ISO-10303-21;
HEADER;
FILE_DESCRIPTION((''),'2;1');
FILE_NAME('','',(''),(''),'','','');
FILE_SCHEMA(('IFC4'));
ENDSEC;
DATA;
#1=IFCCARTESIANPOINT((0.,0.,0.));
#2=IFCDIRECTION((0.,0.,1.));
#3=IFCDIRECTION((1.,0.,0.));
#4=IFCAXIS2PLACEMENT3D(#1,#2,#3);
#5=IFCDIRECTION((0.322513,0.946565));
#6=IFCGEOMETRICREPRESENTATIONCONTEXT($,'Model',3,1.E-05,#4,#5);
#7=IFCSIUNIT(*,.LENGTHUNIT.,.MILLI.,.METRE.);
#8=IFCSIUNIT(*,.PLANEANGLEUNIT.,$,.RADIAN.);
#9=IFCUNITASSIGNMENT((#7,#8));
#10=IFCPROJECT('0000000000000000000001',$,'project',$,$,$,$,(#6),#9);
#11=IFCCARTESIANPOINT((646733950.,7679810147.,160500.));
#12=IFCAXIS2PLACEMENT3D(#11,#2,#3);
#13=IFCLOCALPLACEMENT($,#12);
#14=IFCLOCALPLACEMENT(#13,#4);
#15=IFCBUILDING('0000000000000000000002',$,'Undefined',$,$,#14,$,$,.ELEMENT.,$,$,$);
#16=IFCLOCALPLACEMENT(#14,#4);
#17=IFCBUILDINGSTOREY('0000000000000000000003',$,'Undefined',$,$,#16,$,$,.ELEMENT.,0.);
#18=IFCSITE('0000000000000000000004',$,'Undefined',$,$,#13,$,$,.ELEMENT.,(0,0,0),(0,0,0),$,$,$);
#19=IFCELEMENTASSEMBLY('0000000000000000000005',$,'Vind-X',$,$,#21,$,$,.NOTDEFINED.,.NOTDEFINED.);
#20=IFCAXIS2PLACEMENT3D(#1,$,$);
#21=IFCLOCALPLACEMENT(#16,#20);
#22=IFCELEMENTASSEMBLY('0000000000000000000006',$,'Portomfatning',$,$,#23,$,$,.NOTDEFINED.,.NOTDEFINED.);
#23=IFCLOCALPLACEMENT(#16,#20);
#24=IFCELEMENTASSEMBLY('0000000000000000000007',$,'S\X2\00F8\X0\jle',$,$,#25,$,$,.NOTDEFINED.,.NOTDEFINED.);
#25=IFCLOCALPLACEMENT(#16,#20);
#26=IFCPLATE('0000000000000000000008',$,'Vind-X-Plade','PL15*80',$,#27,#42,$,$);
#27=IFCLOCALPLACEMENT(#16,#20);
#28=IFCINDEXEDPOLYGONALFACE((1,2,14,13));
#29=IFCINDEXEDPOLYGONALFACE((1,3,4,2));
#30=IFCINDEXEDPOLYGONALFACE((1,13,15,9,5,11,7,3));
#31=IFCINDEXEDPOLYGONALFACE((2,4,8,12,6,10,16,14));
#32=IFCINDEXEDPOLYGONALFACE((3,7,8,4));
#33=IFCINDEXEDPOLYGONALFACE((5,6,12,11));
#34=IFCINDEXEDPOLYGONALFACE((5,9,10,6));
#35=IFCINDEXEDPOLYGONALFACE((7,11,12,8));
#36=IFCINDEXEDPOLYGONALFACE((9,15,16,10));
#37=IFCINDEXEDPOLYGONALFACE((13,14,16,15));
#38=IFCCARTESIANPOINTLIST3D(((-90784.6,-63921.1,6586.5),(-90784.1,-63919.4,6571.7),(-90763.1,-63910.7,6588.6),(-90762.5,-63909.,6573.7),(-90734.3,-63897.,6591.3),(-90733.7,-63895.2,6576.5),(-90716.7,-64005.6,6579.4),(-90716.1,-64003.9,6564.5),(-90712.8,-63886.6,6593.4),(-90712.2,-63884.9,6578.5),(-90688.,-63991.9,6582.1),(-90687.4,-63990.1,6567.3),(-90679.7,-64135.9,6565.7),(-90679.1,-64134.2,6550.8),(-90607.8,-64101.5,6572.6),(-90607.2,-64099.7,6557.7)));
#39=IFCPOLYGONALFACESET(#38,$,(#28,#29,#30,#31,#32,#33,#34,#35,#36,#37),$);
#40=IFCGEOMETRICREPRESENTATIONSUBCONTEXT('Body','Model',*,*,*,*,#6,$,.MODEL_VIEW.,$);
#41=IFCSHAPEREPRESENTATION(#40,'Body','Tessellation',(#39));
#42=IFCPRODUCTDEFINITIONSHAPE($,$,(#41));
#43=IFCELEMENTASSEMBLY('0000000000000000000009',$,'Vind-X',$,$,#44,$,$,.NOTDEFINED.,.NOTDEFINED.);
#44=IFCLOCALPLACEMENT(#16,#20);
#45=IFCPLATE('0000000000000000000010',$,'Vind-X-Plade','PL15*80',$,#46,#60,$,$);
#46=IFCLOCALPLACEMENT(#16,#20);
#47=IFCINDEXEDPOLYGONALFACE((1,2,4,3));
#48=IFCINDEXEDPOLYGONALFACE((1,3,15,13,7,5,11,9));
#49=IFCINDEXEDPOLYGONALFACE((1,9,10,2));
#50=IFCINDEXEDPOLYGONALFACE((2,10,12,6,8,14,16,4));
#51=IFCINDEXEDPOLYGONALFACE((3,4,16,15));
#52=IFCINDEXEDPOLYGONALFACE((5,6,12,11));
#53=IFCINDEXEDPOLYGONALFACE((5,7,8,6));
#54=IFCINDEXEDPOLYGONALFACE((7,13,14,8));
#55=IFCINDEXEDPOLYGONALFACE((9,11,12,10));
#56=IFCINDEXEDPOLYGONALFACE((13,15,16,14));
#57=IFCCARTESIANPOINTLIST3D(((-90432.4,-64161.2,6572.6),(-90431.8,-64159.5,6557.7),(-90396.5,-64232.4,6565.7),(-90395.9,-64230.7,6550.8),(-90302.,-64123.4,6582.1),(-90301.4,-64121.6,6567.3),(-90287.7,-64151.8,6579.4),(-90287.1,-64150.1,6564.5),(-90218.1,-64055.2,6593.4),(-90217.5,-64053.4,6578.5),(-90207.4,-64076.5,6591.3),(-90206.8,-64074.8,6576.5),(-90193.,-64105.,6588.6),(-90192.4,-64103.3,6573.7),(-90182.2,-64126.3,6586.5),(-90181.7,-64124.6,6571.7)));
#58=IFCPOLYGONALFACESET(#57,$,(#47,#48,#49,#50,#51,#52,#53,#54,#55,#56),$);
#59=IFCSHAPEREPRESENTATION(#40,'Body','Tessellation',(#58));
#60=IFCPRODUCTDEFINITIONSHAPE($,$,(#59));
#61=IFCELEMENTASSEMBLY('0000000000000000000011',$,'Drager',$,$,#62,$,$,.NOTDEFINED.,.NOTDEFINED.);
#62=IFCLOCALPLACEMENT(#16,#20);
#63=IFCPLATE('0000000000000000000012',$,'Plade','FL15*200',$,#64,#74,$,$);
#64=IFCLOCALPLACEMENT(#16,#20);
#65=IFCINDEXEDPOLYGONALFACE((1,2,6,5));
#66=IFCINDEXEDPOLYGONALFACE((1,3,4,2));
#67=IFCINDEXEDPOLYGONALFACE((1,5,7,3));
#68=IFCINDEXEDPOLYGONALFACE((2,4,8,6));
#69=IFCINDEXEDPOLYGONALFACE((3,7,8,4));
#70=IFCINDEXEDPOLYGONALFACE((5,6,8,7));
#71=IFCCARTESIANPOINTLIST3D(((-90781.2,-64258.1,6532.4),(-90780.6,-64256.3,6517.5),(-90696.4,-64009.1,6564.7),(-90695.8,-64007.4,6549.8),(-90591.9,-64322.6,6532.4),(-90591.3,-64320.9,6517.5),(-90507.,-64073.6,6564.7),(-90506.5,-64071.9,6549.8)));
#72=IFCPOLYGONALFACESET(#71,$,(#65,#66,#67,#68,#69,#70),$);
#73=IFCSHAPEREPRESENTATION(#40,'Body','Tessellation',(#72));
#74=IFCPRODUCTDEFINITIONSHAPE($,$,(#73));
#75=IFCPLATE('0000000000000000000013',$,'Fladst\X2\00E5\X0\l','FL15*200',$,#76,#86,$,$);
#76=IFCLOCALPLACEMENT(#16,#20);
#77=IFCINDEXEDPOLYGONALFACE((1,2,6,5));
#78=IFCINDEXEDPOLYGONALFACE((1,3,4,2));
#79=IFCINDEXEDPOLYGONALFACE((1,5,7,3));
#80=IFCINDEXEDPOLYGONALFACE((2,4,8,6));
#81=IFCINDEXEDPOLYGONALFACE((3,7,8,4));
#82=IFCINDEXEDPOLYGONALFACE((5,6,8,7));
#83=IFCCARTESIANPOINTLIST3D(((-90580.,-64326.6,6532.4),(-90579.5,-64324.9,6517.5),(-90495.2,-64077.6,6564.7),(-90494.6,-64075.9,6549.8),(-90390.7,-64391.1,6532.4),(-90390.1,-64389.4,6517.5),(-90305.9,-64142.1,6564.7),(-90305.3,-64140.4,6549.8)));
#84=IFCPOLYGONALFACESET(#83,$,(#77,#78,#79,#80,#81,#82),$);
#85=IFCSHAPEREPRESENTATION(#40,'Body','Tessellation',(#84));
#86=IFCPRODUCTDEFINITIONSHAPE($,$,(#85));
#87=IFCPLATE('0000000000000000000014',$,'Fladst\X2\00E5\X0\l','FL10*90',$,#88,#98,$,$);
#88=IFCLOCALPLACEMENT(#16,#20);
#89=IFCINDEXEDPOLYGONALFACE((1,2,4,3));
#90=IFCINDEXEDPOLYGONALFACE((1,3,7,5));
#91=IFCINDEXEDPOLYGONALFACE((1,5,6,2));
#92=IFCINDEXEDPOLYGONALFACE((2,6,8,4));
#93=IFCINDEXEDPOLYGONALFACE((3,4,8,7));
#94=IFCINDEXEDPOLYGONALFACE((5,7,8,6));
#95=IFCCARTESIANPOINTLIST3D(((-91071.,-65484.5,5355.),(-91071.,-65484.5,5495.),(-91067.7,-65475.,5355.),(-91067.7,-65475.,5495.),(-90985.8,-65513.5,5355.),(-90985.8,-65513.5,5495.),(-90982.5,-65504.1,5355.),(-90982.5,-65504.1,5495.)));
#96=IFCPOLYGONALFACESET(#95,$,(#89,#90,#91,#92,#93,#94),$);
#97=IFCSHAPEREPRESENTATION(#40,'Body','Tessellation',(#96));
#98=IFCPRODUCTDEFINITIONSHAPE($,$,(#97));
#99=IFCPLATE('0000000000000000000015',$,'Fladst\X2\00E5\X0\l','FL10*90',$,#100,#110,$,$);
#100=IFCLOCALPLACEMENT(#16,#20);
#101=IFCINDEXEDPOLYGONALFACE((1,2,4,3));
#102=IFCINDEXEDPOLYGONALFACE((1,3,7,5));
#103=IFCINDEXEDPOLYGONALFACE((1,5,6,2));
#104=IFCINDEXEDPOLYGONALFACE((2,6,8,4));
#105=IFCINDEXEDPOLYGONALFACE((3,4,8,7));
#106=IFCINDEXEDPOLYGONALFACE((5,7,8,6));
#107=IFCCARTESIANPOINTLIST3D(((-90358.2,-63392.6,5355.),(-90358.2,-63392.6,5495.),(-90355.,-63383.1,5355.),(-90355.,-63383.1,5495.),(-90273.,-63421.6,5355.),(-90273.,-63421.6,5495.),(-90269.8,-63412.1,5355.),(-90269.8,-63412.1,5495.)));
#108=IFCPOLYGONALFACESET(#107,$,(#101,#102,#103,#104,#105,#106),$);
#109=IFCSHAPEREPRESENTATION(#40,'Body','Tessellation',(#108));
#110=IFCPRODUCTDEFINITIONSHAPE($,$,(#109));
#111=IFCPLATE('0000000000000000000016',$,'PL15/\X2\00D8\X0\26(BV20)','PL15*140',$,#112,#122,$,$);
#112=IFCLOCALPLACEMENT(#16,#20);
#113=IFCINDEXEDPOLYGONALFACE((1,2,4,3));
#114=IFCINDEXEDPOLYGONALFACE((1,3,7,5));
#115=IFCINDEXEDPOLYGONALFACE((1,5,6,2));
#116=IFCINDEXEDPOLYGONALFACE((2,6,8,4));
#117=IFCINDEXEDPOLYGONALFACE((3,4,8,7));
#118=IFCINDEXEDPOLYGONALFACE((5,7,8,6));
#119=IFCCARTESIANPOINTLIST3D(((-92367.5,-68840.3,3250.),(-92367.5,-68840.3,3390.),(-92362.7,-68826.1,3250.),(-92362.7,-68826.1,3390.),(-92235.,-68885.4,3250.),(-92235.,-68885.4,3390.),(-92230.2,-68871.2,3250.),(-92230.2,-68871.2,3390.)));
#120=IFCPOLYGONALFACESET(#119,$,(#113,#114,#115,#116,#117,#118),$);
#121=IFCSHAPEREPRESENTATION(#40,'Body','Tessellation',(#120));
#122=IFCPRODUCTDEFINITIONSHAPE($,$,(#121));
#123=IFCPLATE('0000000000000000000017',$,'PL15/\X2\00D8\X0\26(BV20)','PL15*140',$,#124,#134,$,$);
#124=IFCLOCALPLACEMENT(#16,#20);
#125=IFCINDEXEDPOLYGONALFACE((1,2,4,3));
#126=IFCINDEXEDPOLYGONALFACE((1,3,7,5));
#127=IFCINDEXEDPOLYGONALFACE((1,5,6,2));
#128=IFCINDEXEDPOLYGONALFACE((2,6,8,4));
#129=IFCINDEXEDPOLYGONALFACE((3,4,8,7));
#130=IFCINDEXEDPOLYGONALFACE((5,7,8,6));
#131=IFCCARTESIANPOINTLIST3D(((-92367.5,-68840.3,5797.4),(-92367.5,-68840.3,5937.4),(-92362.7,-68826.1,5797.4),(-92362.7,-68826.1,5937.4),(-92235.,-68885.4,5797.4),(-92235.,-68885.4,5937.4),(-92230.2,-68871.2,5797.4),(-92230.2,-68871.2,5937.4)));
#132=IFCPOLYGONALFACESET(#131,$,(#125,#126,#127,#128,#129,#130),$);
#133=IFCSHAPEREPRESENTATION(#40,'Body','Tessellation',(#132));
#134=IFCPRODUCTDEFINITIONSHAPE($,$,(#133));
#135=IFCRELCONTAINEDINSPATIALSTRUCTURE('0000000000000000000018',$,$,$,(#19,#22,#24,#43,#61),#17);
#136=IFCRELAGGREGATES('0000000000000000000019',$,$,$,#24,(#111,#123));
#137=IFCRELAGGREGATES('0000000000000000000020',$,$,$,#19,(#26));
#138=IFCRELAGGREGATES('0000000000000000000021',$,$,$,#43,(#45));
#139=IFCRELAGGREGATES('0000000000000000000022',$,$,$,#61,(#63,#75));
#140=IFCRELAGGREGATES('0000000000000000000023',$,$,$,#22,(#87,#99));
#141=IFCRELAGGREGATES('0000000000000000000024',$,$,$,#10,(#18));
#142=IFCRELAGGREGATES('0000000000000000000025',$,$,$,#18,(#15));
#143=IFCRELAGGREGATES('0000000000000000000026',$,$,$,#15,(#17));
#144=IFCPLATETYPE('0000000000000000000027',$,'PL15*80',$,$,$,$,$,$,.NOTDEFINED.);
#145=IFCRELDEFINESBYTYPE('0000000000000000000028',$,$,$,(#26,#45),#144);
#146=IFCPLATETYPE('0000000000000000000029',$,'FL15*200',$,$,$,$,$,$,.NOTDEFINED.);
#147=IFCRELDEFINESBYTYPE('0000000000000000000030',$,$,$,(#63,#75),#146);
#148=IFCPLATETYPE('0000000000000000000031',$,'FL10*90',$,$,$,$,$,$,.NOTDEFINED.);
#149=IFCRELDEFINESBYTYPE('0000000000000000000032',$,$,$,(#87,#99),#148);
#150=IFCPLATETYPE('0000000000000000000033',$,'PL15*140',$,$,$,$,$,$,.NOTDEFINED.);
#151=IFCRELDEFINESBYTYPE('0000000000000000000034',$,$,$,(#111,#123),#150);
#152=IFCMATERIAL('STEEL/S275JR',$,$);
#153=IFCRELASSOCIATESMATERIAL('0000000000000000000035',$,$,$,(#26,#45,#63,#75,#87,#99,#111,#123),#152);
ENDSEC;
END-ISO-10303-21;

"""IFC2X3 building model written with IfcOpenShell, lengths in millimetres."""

from ifc_helpers import new_model, si_unit, direction, frame, origin_with_axes, place, context, subcontext, project, spatial, polyline, outline, extrude, boolean, material, type_object, element, aggregate, save


model = new_model("IFC2X3")

# Units and contexts
model_context = context("Model", 3, precision=1e-05, world=origin_with_axes(), true_north=direction((0.322513, 0.946565)))
body_context = subcontext(model_context, "Body", "Model", "MODEL_VIEW")
ifc_project = project(units=[si_unit("LENGTHUNIT", "METRE", prefix="MILLI"), si_unit("PLANEANGLEUNIT", "RADIAN")], contexts=[model_context])

# Site, building, storey
site_placement = place(None, frame((646733950.0, 7679810147.0, 160500.0), z_axis=(0.0, 0.0, 1.0), x_axis=(1.0, 0.0, 0.0)))
site = spatial("IfcSite", under=ifc_project, at=site_placement, Name="Undefined", CompositionType="ELEMENT", RefLatitude=(0, 0, 0), RefLongitude=(0, 0, 0))
building_placement = place(site_placement, origin_with_axes())
building = spatial("IfcBuilding", under=site, at=building_placement, Name="Undefined", CompositionType="ELEMENT")
storey_placement = place(building_placement, origin_with_axes())
storey = spatial("IfcBuildingStorey", under=building, at=storey_placement, Name="Undefined", CompositionType="ELEMENT", Elevation=0.0)

# Element assembly
assembly_1_placement = place(storey_placement, origin_with_axes())
assembly_1 = element("IfcElementAssembly", 1, at=assembly_1_placement, inside=storey, Name="Vind-X", AssemblyPlace="NOTDEFINED", PredefinedType="NOTDEFINED")

# Element assembly
assembly_2_placement = place(storey_placement, origin_with_axes())
assembly_2 = element("IfcElementAssembly", 2, at=assembly_2_placement, inside=storey, Name="Portomfatning", AssemblyPlace="NOTDEFINED", PredefinedType="NOTDEFINED")

# Element assembly
assembly_3_placement = place(storey_placement, origin_with_axes())
assembly_3 = element("IfcElementAssembly", 3, at=assembly_3_placement, inside=storey, Name="Søjle", AssemblyPlace="NOTDEFINED", PredefinedType="NOTDEFINED")
ifc_material_1 = material(Name="STEEL/S275JR")

# Plate
plate_type_1 = type_object("IfcPlateType", Name="PL15*80", PredefinedType="NOTDEFINED")
plate_1_placement = place(assembly_1_placement, frame((-90679.4, -64135.1, 6558.3), z_axis=(-0.039304, -0.115357, 0.992546), x_axis=(0.898474, 0.430595, 0.085625)))
plate_1 = element("IfcPlate", 4, at=plate_1_placement, type_object=plate_type_1, material=ifc_material_1, Name="Vind-X-Plade", Description="PL15*80", context=body_context, shape_type="CSG", body=[
    boolean("DIFFERENCE", extrude(outline(polyline([(0.0, 0.0), (80.0, 0.0), (80.0, 240.0), (0.0, 240.0), (0.0, 0.0)])), frame((0.0, 0.0, -7.5), z_axis=(0.0, 0.0, 1.0), x_axis=(1.0, 0.0, 0.0)), (0.0, 0.0, 1.0), 15.0), extrude(outline(polyline([(0.0, 0.0), (106.0, 0.0), (106.0, 32.0), (0.0, 32.0), (0.0, 0.0)])), frame((56.0, 240.0, 8.5), z_axis=(0.0, 0.0, -1.0), x_axis=(0.0, -1.0, 0.0)), (0.0, 0.0, 1.0), 17.0)),
])

# Element assembly, plate
assembly_4_placement = place(storey_placement, origin_with_axes())
assembly_4 = element("IfcElementAssembly", 5, at=assembly_4_placement, inside=storey, Name="Vind-X", AssemblyPlace="NOTDEFINED", PredefinedType="NOTDEFINED")
plate_2_placement = place(assembly_4_placement, frame((-90396.2, -64231.5, 6558.3), z_axis=(0.039304, 0.115357, -0.992546), x_axis=(-0.448662, 0.88959, 0.085625)))
plate_2 = element("IfcPlate", 6, at=plate_2_placement, type_object=plate_type_1, material=ifc_material_1, Name="Vind-X-Plade", Description="PL15*80", context=body_context, shape_type="CSG", body=[
    boolean("DIFFERENCE", extrude(outline(polyline([(0.0, 0.0), (80.0, 0.0), (80.0, 240.0), (0.0, 240.0), (0.0, 0.0)])), frame((0.0, 0.0, -7.5), z_axis=(0.0, 0.0, 1.0), x_axis=(1.0, 0.0, 0.0)), (0.0, 0.0, 1.0), 15.0), extrude(outline(polyline([(0.0, 0.0), (106.0, 0.0), (106.0, 32.0), (0.0, 32.0), (0.0, 0.0)])), frame((56.0, 240.0, 8.5), z_axis=(0.0, 0.0, -1.0), x_axis=(0.0, -1.0, 0.0)), (0.0, 0.0, 1.0), 17.0)),
])

# Element assembly, plates
assembly_5_placement = place(storey_placement, origin_with_axes())
assembly_5 = element("IfcElementAssembly", 7, at=assembly_5_placement, inside=storey, Name="Drager", AssemblyPlace="NOTDEFINED", PredefinedType="NOTDEFINED")
plate_type_2 = type_object("IfcPlateType", Name="FL15*200", PredefinedType="NOTDEFINED")
plate_3_placement = place(assembly_5_placement, frame((-90591.6, -64321.7, 6524.9), z_axis=(-0.039304, -0.115357, 0.992546), x_axis=(0.320109, 0.93951, 0.121869)))
plate_3 = element("IfcPlate", 8, at=plate_3_placement, type_object=plate_type_2, material=ifc_material_1, Name="Plade", Description="FL15*200", context=body_context, shape_type="SweptSolid", body=[
    extrude(outline(polyline([(0.0, 0.0), (265.0, 0.0), (265.0, 200.0), (0.0, 200.0), (0.0, 0.0)])), frame((0.0, 0.0, -7.5), z_axis=(0.0, 0.0, 1.0), x_axis=(1.0, 0.0, 0.0)), (0.0, 0.0, 1.0), 15.0),
])
plate_4_placement = place(assembly_5_placement, frame((-90494.9, -64076.8, 6557.2), z_axis=(-0.039304, -0.115357, 0.992546), x_axis=(-0.320109, -0.93951, -0.121869)))
plate_4 = element("IfcPlate", 9, at=plate_4_placement, type_object=plate_type_2, material=ifc_material_1, Name="Fladstål", Description="FL15*200", context=body_context, shape_type="SweptSolid", body=[
    extrude(outline(polyline([(0.0, 0.0), (265.0, 0.0), (265.0, 200.0), (0.0, 200.0), (0.0, 0.0)])), frame((0.0, 0.0, -7.5), z_axis=(0.0, 0.0, 1.0), x_axis=(1.0, 0.0, 0.0)), (0.0, 0.0, 1.0), 15.0),
])

# Plates
plate_type_3 = type_object("IfcPlateType", Name="FL10*90", PredefinedType="NOTDEFINED")
plate_5_placement = place(assembly_2_placement, frame((-91026.8, -65494.3, 5355.0), z_axis=(0.322513, 0.946565, 0.0), x_axis=(0.0, 0.0, 1.0)))
plate_5 = element("IfcPlate", 10, at=plate_5_placement, type_object=plate_type_3, material=ifc_material_1, Name="Fladstål", Description="FL10*90", context=body_context, shape_type="SweptSolid", body=[
    extrude(outline(polyline([(0.0, -45.0), (0.0, 45.0), (140.0, 45.0), (140.0, -45.0), (0.0, -45.0)])), frame((0.0, 0.0, -5.0), z_axis=(0.0, 0.0, 1.0), x_axis=(1.0, 0.0, 0.0)), (0.0, 0.0, 1.0), 10.0),
])
plate_6_placement = place(assembly_2_placement, frame((-90314.0, -63402.4, 5355.0), z_axis=(-0.322513, -0.946565, 0.0), x_axis=(0.0, 0.0, 1.0)))
plate_6 = element("IfcPlate", 11, at=plate_6_placement, type_object=plate_type_3, material=ifc_material_1, Name="Fladstål", Description="FL10*90", context=body_context, shape_type="SweptSolid", body=[
    extrude(outline(polyline([(0.0, -45.0), (0.0, 45.0), (140.0, 45.0), (140.0, -45.0), (0.0, -45.0)])), frame((0.0, 0.0, -5.0), z_axis=(0.0, 0.0, 1.0), x_axis=(1.0, 0.0, 0.0)), (0.0, 0.0, 1.0), 10.0),
])
plate_type_4 = type_object("IfcPlateType", Name="PL15*140", PredefinedType="NOTDEFINED")
plate_7_placement = place(assembly_3_placement, frame((-92365.1, -68833.2, 3250.0), z_axis=(-0.322513, -0.946565, 0.0), x_axis=(0.946565, -0.322513, 0.0)))
plate_7 = element("IfcPlate", 12, at=plate_7_placement, type_object=plate_type_4, material=ifc_material_1, Name="PL15/Ø26(BV20)", Description="PL15*140", context=body_context, shape_type="SweptSolid", body=[
    extrude(outline(polyline([(0.0, 0.0), (140.0, 0.0), (140.0, 140.0), (0.0, 140.0), (0.0, 0.0)])), frame((0.0, 0.0, -7.5), z_axis=(0.0, 0.0, 1.0), x_axis=(1.0, 0.0, 0.0)), (0.0, 0.0, 1.0), 15.0),
])
plate_8_placement = place(assembly_3_placement, frame((-92365.1, -68833.2, 5797.4), z_axis=(-0.322513, -0.946565, 0.0), x_axis=(0.946565, -0.322513, 0.0)))
plate_8 = element("IfcPlate", 13, at=plate_8_placement, type_object=plate_type_4, material=ifc_material_1, Name="PL15/Ø26(BV20)", Description="PL15*140", context=body_context, shape_type="SweptSolid", body=[
    extrude(outline(polyline([(0.0, 0.0), (140.0, 0.0), (140.0, 140.0), (0.0, 140.0), (0.0, 0.0)])), frame((0.0, 0.0, -7.5), z_axis=(0.0, 0.0, 1.0), x_axis=(1.0, 0.0, 0.0)), (0.0, 0.0, 1.0), 15.0),
])
aggregate(assembly_3, [plate_7, plate_8])

aggregate(assembly_1, [plate_1])
aggregate(assembly_4, [plate_2])

aggregate(assembly_5, [plate_3, plate_4])
aggregate(assembly_2, [plate_5, plate_6])

save(model, "model.ifc")
